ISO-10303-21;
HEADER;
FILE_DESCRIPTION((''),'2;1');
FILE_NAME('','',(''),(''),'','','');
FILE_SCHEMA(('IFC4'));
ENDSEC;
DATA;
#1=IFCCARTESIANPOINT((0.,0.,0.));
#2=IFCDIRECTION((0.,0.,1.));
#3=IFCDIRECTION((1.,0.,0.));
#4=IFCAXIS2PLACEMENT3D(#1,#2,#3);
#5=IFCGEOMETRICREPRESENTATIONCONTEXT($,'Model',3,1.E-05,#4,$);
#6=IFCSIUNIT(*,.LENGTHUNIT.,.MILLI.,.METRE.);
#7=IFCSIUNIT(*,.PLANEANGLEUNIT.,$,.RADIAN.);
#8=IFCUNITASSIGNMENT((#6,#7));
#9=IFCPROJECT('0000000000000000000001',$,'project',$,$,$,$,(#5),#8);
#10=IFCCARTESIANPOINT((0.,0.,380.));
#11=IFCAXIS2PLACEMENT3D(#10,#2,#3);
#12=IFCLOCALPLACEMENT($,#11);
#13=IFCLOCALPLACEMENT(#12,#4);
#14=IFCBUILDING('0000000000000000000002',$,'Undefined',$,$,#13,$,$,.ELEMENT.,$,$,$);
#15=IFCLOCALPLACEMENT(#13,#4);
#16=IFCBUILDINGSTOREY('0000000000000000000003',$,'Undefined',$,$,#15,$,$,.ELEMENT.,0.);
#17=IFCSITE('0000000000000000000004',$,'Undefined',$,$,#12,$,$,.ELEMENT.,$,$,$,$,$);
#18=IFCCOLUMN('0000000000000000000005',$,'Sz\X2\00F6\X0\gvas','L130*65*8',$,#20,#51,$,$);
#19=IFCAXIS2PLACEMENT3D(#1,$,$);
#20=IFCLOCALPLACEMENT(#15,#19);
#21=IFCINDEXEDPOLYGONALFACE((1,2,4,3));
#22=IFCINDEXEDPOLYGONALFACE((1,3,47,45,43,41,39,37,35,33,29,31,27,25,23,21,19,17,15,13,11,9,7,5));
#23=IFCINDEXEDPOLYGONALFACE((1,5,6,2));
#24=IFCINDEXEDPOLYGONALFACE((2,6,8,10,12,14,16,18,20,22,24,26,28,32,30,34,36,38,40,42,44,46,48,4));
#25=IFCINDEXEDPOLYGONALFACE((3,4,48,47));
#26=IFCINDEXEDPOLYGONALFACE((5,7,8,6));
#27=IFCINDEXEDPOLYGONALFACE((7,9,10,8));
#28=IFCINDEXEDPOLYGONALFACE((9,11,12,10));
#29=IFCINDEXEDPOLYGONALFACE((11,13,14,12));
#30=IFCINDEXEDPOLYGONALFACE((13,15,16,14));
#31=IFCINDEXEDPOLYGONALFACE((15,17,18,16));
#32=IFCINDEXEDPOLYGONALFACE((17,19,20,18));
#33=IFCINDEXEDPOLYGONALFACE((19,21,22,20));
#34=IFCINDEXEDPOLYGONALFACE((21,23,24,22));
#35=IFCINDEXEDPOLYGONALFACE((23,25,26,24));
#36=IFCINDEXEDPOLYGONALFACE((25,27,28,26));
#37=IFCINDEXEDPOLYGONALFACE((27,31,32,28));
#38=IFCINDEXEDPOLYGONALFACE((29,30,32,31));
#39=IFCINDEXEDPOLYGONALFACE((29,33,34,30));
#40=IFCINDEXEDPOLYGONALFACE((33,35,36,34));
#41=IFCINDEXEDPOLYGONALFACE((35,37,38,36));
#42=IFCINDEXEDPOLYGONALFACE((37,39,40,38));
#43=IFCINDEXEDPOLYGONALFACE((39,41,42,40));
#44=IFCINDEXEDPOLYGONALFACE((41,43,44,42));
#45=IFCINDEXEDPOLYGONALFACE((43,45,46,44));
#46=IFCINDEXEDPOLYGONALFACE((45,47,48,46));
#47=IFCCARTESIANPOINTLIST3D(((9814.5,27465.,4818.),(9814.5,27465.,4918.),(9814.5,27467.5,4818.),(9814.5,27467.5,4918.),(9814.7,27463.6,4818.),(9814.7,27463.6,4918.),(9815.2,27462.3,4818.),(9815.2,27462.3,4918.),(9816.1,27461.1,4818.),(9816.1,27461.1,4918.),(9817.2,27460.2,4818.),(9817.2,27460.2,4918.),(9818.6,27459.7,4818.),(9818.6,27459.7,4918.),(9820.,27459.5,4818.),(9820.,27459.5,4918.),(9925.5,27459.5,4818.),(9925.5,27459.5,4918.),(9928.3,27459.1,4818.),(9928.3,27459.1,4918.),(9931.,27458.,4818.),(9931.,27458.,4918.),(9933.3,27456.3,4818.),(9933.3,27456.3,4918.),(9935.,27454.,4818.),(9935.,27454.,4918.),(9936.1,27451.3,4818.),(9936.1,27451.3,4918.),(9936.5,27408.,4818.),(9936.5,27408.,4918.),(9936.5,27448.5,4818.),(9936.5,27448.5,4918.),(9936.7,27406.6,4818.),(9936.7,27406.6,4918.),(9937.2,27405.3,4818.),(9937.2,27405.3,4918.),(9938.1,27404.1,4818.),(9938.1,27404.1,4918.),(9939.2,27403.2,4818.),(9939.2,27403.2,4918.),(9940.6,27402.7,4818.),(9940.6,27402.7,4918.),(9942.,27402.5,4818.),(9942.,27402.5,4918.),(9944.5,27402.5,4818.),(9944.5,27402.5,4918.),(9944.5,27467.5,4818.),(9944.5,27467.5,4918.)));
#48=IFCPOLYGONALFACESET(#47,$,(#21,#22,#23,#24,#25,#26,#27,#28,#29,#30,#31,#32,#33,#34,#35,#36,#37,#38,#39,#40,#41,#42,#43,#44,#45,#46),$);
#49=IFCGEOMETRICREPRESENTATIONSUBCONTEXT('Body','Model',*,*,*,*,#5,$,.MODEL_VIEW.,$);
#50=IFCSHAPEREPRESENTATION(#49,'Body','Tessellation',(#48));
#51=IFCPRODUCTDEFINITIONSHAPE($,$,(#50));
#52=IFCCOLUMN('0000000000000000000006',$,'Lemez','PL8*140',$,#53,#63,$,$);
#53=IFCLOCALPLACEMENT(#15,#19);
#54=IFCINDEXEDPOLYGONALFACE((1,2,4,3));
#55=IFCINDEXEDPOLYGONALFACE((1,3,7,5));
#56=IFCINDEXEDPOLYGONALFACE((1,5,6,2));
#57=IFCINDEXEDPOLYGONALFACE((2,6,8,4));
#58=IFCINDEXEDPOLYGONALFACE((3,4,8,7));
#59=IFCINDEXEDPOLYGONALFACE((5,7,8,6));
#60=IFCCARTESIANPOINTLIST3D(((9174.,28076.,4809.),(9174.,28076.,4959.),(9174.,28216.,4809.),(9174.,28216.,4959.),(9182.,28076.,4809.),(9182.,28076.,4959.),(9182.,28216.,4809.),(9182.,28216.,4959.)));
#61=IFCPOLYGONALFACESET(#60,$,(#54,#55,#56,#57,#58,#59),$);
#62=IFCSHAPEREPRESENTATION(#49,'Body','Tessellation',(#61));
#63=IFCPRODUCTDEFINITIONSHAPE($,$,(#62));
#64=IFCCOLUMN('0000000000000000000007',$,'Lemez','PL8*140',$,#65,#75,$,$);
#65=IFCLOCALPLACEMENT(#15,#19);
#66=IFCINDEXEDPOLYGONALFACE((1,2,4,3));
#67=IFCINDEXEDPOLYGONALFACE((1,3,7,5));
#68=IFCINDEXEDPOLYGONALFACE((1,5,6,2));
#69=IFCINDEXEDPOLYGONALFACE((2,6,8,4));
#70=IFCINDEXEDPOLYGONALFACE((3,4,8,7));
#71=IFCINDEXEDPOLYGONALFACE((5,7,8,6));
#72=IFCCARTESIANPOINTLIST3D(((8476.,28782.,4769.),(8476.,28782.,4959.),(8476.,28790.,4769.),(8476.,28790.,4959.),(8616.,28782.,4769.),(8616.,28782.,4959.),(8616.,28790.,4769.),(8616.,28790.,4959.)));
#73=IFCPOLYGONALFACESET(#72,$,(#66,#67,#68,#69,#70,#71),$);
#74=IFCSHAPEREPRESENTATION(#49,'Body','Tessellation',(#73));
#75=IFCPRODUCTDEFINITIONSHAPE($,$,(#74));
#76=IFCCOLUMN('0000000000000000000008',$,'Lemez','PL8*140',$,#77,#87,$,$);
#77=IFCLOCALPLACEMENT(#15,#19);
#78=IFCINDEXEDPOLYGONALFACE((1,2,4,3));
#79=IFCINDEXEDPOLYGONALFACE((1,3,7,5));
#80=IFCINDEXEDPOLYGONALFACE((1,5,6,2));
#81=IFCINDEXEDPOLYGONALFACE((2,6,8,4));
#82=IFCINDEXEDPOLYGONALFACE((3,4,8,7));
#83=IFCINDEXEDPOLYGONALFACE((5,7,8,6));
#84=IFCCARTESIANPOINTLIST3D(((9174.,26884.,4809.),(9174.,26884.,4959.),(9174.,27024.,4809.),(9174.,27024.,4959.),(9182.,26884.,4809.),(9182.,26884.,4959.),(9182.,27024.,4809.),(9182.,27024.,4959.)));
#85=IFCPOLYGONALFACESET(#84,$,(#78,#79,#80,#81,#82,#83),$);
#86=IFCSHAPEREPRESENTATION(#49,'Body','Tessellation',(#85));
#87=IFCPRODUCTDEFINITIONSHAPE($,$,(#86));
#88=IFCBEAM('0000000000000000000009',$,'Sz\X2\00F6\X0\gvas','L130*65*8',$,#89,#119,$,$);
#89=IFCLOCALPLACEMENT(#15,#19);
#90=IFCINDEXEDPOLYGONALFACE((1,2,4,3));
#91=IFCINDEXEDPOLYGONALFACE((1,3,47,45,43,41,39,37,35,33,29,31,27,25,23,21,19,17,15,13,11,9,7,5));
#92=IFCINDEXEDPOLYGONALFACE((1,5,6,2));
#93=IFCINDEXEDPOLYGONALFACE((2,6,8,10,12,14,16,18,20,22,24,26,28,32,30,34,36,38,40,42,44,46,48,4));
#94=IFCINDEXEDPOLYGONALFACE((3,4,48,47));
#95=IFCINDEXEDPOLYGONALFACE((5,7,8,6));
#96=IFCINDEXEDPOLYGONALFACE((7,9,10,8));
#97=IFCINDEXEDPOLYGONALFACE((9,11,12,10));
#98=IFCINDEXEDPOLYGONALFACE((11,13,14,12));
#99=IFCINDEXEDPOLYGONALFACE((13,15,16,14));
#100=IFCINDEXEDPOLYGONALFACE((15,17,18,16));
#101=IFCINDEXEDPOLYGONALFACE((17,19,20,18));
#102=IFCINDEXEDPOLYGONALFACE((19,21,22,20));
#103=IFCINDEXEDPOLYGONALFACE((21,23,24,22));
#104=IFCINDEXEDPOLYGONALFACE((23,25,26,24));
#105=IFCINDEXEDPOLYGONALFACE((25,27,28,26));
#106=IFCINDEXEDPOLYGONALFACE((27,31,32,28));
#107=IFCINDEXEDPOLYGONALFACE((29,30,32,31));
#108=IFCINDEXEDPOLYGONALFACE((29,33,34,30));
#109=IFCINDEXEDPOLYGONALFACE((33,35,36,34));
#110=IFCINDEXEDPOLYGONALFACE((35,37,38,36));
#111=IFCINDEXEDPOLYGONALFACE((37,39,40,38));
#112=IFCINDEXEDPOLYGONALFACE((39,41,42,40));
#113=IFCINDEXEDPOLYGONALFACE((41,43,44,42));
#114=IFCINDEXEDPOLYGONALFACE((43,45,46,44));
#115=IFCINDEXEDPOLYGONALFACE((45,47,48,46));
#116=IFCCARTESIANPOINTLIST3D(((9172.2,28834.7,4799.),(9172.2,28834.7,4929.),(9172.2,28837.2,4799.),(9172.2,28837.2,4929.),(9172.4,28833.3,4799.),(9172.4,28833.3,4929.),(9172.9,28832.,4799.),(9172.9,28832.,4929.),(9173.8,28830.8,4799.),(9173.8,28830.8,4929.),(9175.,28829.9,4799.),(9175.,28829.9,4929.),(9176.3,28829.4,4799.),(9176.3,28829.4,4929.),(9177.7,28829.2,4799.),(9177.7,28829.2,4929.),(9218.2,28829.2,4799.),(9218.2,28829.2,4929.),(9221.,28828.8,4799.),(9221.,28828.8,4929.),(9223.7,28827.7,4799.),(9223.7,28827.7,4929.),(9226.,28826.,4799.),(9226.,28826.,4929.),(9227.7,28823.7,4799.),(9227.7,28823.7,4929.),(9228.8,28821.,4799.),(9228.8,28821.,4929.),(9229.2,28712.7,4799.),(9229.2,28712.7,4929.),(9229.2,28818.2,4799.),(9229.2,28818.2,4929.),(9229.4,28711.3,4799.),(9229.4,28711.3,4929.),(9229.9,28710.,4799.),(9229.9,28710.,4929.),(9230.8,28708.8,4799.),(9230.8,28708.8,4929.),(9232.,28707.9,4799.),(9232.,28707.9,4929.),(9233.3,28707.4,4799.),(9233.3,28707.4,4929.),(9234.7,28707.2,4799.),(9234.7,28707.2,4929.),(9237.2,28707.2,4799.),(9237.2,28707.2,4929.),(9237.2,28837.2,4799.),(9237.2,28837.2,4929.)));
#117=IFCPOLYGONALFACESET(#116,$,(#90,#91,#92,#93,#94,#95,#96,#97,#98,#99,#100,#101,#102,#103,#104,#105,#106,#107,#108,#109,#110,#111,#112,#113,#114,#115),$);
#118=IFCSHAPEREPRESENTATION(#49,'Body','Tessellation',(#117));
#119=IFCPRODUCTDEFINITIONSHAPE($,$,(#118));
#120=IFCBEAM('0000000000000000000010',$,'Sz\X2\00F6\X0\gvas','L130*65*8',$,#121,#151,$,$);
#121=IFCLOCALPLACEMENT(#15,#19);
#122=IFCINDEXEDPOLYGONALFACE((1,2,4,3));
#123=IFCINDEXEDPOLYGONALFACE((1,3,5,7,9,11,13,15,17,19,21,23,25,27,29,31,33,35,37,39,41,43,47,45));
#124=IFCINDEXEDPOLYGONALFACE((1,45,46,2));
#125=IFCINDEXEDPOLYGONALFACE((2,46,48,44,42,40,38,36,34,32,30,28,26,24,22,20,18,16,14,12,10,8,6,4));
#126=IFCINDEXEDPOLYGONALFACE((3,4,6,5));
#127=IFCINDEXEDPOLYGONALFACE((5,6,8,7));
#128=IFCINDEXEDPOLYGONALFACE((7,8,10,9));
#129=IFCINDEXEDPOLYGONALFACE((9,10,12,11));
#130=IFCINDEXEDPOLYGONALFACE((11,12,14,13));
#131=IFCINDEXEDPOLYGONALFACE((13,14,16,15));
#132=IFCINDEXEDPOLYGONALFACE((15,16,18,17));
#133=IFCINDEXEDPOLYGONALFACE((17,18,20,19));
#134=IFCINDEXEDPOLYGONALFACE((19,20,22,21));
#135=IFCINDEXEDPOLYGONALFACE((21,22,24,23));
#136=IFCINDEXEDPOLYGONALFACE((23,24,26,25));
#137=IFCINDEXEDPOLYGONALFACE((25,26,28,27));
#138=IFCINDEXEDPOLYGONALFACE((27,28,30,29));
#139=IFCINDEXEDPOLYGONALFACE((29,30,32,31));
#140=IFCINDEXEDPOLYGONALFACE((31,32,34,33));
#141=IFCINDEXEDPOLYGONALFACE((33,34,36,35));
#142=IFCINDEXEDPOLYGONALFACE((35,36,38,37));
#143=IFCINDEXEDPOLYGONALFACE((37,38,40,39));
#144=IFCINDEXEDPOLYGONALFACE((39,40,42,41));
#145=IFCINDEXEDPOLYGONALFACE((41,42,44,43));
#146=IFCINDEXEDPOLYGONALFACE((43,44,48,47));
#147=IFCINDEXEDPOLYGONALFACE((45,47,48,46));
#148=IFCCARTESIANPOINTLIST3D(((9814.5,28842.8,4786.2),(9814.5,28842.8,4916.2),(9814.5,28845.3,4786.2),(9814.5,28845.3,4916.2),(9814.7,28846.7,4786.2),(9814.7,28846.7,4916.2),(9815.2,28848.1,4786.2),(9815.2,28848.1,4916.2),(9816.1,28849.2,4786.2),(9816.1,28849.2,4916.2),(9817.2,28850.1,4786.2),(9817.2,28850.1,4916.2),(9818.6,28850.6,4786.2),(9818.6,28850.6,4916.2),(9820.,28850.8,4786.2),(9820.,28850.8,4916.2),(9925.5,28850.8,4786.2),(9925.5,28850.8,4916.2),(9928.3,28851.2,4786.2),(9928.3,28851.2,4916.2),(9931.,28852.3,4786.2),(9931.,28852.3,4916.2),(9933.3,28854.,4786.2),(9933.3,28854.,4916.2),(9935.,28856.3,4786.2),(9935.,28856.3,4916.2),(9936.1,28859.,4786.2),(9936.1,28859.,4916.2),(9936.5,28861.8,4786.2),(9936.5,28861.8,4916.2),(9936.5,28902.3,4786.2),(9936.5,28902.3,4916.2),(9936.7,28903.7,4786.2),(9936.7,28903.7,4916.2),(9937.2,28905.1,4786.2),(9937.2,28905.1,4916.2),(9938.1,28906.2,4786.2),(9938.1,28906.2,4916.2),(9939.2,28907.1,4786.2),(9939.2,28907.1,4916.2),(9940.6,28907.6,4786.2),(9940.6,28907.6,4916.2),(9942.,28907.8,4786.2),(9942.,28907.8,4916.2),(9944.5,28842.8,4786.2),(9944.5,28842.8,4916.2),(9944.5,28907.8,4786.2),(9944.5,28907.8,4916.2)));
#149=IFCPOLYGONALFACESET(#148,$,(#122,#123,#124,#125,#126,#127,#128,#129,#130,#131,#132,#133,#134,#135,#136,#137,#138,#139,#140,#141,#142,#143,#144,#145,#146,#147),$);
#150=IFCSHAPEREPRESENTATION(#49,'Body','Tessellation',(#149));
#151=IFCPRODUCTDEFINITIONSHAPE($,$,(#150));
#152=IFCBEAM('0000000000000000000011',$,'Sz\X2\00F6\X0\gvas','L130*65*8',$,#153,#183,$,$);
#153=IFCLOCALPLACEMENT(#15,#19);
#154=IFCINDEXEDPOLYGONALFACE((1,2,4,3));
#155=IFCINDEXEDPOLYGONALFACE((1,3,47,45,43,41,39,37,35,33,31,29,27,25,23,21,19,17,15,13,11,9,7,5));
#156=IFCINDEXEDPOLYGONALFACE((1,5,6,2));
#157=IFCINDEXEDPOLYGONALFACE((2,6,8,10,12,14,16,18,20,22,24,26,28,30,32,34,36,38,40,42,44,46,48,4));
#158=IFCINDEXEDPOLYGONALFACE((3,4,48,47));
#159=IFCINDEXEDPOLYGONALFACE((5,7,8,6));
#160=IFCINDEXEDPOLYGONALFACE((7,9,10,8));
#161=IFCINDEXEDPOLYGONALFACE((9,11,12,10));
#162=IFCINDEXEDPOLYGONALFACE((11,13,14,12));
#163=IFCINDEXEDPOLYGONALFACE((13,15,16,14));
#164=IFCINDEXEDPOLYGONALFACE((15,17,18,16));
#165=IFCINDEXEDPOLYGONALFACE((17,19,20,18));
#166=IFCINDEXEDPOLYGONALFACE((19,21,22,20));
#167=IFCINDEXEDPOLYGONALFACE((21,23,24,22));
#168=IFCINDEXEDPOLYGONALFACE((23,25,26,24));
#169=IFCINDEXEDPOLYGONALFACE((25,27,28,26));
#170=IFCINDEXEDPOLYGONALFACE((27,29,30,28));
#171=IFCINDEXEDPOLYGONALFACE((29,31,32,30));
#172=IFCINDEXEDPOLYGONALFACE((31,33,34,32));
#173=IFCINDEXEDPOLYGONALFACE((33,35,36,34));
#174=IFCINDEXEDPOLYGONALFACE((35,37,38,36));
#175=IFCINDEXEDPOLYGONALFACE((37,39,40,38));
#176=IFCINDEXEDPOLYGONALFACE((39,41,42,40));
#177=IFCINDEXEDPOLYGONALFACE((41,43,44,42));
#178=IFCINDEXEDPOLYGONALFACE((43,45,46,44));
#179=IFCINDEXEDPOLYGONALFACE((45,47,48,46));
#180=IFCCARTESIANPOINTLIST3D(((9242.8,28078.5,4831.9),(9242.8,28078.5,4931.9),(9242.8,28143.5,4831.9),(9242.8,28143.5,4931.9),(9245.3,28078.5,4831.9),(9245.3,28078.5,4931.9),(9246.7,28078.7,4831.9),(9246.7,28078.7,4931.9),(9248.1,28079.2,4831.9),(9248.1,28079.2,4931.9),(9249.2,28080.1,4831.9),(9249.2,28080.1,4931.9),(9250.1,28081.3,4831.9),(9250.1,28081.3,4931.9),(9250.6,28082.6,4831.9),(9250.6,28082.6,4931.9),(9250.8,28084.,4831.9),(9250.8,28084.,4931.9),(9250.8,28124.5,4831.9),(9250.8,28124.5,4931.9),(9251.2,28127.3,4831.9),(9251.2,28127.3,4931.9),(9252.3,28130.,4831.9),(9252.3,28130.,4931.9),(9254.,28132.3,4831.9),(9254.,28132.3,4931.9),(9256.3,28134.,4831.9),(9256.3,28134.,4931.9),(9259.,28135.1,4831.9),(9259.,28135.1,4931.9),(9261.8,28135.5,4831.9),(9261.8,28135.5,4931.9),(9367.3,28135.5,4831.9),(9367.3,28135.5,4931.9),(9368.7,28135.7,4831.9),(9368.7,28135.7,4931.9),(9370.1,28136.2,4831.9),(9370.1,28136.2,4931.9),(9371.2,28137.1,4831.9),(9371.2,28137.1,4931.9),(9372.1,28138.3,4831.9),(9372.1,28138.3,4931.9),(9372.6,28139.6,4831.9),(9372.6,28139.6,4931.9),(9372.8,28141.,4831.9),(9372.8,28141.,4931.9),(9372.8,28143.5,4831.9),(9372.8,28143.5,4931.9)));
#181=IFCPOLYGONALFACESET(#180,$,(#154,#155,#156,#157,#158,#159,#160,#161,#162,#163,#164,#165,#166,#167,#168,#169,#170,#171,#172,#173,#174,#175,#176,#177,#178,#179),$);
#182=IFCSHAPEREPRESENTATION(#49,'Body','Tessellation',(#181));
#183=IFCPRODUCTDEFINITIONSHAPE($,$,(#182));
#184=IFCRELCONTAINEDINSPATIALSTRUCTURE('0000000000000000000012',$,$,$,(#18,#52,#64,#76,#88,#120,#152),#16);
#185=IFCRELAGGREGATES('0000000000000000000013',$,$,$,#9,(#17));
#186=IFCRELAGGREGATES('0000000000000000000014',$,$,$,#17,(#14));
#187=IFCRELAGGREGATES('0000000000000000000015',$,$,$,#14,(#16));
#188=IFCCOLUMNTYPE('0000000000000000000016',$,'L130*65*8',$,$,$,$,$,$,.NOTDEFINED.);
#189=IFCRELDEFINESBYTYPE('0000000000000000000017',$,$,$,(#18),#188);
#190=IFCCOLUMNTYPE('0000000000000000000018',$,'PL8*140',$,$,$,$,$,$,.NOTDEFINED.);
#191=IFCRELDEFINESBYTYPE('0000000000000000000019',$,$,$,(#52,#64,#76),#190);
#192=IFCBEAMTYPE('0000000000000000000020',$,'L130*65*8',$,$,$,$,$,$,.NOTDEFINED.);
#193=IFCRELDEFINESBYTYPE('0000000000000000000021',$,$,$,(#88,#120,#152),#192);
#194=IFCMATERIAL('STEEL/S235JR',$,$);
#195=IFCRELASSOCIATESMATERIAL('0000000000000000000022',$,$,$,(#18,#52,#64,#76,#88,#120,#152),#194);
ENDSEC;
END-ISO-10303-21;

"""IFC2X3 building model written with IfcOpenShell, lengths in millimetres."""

from ifc_helpers import new_model, si_unit, frame, origin_with_axes, origin_2d_with_axis, place, context, subcontext, project, spatial, rectangle, l_section, extrude, material, type_object, element, save


model = new_model("IFC2X3")

# Units and contexts
model_context = context("Model", 3, precision=1e-05, world=origin_with_axes())
body_context = subcontext(model_context, "Body", "Model", "MODEL_VIEW")
ifc_project = project(units=[si_unit("LENGTHUNIT", "METRE", prefix="MILLI"), si_unit("PLANEANGLEUNIT", "RADIAN")], contexts=[model_context])

# Site, building, storey
site_placement = place(None, frame((0.0, 0.0, 380.0), z_axis=(0.0, 0.0, 1.0), x_axis=(1.0, 0.0, 0.0)))
site = spatial("IfcSite", under=ifc_project, at=site_placement, Name="Undefined", CompositionType="ELEMENT")
building_placement = place(site_placement, origin_with_axes())
building = spatial("IfcBuilding", under=site, at=building_placement, Name="Undefined", CompositionType="ELEMENT")
storey_placement = place(building_placement, origin_with_axes())
storey = spatial("IfcBuildingStorey", under=building, at=storey_placement, Name="Undefined", CompositionType="ELEMENT", Elevation=0.0)

# Columns
ifc_material = material(Name="STEEL/S235JR")
column_type_1 = type_object("IfcColumnType", Name="L130*65*8", PredefinedType="NOTDEFINED")
column_1_placement = place(storey_placement, frame((9879.5, 27435.0, 4818.0), z_axis=(0.0, 0.0, 1.0), x_axis=(-1.0, 0.0, 0.0)))
element("IfcColumn", 1, at=column_1_placement, inside=storey, type_object=column_type_1, material=ifc_material, Name="Szögvas", Description="L130*65*8", context=body_context, shape_type="SweptSolid", body=[
    extrude(l_section(Depth=130.0, Width=65.0, Thickness=8.0, FilletRadius=11.0, EdgeRadius=5.5, at=origin_2d_with_axis()), frame((0.0, 0.0, 100.0), z_axis=(0.0, 0.0, -1.0), x_axis=(0.0, 1.0, 0.0)), (0.0, 0.0, 1.0), 100.0),
])
column_type_2 = type_object("IfcColumnType", Name="PL8*140", PredefinedType="NOTDEFINED")
column_2_placement = place(storey_placement, frame((9178.0, 28146.0, 4809.0), z_axis=(0.0, 0.0, 1.0), x_axis=(0.0, 1.0, 0.0)))
element("IfcColumn", 2, at=column_2_placement, inside=storey, type_object=column_type_2, material=ifc_material, Name="Lemez", Description="PL8*140", context=body_context, shape_type="SweptSolid", body=[
    extrude(rectangle(XDim=8.0, YDim=140.0, at=origin_2d_with_axis()), frame((0.0, 0.0, 150.0), z_axis=(0.0, 0.0, -1.0), x_axis=(0.0, 1.0, 0.0)), (0.0, 0.0, 1.0), 150.0),
])
column_3_placement = place(storey_placement, frame((8546.0, 28786.0, 4769.0), z_axis=(0.0, 0.0, 1.0), x_axis=(-1.0, 0.0, 0.0)))
element("IfcColumn", 3, at=column_3_placement, inside=storey, type_object=column_type_2, material=ifc_material, Name="Lemez", Description="PL8*140", context=body_context, shape_type="SweptSolid", body=[
    extrude(rectangle(XDim=8.0, YDim=140.0, at=origin_2d_with_axis()), frame((0.0, 0.0, 190.0), z_axis=(0.0, 0.0, -1.0), x_axis=(0.0, 1.0, 0.0)), (0.0, 0.0, 1.0), 190.0),
])
column_4_placement = place(storey_placement, frame((9178.0, 26954.0, 4809.0), z_axis=(0.0, 0.0, 1.0), x_axis=(0.0, 1.0, 0.0)))
element("IfcColumn", 4, at=column_4_placement, inside=storey, type_object=column_type_2, material=ifc_material, Name="Lemez", Description="PL8*140", context=body_context, shape_type="SweptSolid", body=[
    extrude(rectangle(XDim=8.0, YDim=140.0, at=origin_2d_with_axis()), frame((0.0, 0.0, 150.0), z_axis=(0.0, 0.0, -1.0), x_axis=(0.0, 1.0, 0.0)), (0.0, 0.0, 1.0), 150.0),
])

# Beams
beam_type_1 = type_object("IfcBeamType", Name="L130*65*8", PredefinedType="NOTDEFINED")
for number, where, z_axis, x_axis, name in (
    (5, (9204.7, 28772.2, 4929.0), (0.0, -1.0, 0.0), (0.0, 0.0, -1.0), "Szögvas"),
    (6, (9879.5, 28875.3, 4916.3), (-1.0, 0.0, 0.0), (0.0, 0.0, -1.0), "Szögvas"),
):
    element("IfcBeam", number, at=place(storey_placement, frame(where, z_axis=z_axis, x_axis=x_axis)), inside=storey, type_object=beam_type_1, material=ifc_material, Name=name, Description="L130*65*8", context=body_context, shape_type="SweptSolid", body=[
        extrude(l_section(Depth=130.0, Width=65.0, Thickness=8.0, FilletRadius=11.0, EdgeRadius=5.5, at=origin_2d_with_axis()), frame((130.0, 0.0, 0.0), z_axis=(-1.0, 0.0, 0.0), x_axis=(0.0, -1.0, 0.0)), (0.0, 0.0, 1.0), 130.0),
    ])
beam_1_placement = place(storey_placement, frame((9307.8, 28111.0, 4932.0), z_axis=(1.0, 0.0, 0.0), x_axis=(0.0, 0.0, -1.0)))
element("IfcBeam", 7, at=beam_1_placement, inside=storey, type_object=beam_type_1, material=ifc_material, Name="Szögvas", Description="L130*65*8", context=body_context, shape_type="SweptSolid", body=[
    extrude(l_section(Depth=130.0, Width=65.0, Thickness=8.0, FilletRadius=11.0, EdgeRadius=5.5, at=origin_2d_with_axis()), frame((100.0, 0.0, 0.0), z_axis=(-1.0, 0.0, 0.0), x_axis=(0.0, -1.0, 0.0)), (0.0, 0.0, 1.0), 100.0),
])

save(model, "model.ifc")
